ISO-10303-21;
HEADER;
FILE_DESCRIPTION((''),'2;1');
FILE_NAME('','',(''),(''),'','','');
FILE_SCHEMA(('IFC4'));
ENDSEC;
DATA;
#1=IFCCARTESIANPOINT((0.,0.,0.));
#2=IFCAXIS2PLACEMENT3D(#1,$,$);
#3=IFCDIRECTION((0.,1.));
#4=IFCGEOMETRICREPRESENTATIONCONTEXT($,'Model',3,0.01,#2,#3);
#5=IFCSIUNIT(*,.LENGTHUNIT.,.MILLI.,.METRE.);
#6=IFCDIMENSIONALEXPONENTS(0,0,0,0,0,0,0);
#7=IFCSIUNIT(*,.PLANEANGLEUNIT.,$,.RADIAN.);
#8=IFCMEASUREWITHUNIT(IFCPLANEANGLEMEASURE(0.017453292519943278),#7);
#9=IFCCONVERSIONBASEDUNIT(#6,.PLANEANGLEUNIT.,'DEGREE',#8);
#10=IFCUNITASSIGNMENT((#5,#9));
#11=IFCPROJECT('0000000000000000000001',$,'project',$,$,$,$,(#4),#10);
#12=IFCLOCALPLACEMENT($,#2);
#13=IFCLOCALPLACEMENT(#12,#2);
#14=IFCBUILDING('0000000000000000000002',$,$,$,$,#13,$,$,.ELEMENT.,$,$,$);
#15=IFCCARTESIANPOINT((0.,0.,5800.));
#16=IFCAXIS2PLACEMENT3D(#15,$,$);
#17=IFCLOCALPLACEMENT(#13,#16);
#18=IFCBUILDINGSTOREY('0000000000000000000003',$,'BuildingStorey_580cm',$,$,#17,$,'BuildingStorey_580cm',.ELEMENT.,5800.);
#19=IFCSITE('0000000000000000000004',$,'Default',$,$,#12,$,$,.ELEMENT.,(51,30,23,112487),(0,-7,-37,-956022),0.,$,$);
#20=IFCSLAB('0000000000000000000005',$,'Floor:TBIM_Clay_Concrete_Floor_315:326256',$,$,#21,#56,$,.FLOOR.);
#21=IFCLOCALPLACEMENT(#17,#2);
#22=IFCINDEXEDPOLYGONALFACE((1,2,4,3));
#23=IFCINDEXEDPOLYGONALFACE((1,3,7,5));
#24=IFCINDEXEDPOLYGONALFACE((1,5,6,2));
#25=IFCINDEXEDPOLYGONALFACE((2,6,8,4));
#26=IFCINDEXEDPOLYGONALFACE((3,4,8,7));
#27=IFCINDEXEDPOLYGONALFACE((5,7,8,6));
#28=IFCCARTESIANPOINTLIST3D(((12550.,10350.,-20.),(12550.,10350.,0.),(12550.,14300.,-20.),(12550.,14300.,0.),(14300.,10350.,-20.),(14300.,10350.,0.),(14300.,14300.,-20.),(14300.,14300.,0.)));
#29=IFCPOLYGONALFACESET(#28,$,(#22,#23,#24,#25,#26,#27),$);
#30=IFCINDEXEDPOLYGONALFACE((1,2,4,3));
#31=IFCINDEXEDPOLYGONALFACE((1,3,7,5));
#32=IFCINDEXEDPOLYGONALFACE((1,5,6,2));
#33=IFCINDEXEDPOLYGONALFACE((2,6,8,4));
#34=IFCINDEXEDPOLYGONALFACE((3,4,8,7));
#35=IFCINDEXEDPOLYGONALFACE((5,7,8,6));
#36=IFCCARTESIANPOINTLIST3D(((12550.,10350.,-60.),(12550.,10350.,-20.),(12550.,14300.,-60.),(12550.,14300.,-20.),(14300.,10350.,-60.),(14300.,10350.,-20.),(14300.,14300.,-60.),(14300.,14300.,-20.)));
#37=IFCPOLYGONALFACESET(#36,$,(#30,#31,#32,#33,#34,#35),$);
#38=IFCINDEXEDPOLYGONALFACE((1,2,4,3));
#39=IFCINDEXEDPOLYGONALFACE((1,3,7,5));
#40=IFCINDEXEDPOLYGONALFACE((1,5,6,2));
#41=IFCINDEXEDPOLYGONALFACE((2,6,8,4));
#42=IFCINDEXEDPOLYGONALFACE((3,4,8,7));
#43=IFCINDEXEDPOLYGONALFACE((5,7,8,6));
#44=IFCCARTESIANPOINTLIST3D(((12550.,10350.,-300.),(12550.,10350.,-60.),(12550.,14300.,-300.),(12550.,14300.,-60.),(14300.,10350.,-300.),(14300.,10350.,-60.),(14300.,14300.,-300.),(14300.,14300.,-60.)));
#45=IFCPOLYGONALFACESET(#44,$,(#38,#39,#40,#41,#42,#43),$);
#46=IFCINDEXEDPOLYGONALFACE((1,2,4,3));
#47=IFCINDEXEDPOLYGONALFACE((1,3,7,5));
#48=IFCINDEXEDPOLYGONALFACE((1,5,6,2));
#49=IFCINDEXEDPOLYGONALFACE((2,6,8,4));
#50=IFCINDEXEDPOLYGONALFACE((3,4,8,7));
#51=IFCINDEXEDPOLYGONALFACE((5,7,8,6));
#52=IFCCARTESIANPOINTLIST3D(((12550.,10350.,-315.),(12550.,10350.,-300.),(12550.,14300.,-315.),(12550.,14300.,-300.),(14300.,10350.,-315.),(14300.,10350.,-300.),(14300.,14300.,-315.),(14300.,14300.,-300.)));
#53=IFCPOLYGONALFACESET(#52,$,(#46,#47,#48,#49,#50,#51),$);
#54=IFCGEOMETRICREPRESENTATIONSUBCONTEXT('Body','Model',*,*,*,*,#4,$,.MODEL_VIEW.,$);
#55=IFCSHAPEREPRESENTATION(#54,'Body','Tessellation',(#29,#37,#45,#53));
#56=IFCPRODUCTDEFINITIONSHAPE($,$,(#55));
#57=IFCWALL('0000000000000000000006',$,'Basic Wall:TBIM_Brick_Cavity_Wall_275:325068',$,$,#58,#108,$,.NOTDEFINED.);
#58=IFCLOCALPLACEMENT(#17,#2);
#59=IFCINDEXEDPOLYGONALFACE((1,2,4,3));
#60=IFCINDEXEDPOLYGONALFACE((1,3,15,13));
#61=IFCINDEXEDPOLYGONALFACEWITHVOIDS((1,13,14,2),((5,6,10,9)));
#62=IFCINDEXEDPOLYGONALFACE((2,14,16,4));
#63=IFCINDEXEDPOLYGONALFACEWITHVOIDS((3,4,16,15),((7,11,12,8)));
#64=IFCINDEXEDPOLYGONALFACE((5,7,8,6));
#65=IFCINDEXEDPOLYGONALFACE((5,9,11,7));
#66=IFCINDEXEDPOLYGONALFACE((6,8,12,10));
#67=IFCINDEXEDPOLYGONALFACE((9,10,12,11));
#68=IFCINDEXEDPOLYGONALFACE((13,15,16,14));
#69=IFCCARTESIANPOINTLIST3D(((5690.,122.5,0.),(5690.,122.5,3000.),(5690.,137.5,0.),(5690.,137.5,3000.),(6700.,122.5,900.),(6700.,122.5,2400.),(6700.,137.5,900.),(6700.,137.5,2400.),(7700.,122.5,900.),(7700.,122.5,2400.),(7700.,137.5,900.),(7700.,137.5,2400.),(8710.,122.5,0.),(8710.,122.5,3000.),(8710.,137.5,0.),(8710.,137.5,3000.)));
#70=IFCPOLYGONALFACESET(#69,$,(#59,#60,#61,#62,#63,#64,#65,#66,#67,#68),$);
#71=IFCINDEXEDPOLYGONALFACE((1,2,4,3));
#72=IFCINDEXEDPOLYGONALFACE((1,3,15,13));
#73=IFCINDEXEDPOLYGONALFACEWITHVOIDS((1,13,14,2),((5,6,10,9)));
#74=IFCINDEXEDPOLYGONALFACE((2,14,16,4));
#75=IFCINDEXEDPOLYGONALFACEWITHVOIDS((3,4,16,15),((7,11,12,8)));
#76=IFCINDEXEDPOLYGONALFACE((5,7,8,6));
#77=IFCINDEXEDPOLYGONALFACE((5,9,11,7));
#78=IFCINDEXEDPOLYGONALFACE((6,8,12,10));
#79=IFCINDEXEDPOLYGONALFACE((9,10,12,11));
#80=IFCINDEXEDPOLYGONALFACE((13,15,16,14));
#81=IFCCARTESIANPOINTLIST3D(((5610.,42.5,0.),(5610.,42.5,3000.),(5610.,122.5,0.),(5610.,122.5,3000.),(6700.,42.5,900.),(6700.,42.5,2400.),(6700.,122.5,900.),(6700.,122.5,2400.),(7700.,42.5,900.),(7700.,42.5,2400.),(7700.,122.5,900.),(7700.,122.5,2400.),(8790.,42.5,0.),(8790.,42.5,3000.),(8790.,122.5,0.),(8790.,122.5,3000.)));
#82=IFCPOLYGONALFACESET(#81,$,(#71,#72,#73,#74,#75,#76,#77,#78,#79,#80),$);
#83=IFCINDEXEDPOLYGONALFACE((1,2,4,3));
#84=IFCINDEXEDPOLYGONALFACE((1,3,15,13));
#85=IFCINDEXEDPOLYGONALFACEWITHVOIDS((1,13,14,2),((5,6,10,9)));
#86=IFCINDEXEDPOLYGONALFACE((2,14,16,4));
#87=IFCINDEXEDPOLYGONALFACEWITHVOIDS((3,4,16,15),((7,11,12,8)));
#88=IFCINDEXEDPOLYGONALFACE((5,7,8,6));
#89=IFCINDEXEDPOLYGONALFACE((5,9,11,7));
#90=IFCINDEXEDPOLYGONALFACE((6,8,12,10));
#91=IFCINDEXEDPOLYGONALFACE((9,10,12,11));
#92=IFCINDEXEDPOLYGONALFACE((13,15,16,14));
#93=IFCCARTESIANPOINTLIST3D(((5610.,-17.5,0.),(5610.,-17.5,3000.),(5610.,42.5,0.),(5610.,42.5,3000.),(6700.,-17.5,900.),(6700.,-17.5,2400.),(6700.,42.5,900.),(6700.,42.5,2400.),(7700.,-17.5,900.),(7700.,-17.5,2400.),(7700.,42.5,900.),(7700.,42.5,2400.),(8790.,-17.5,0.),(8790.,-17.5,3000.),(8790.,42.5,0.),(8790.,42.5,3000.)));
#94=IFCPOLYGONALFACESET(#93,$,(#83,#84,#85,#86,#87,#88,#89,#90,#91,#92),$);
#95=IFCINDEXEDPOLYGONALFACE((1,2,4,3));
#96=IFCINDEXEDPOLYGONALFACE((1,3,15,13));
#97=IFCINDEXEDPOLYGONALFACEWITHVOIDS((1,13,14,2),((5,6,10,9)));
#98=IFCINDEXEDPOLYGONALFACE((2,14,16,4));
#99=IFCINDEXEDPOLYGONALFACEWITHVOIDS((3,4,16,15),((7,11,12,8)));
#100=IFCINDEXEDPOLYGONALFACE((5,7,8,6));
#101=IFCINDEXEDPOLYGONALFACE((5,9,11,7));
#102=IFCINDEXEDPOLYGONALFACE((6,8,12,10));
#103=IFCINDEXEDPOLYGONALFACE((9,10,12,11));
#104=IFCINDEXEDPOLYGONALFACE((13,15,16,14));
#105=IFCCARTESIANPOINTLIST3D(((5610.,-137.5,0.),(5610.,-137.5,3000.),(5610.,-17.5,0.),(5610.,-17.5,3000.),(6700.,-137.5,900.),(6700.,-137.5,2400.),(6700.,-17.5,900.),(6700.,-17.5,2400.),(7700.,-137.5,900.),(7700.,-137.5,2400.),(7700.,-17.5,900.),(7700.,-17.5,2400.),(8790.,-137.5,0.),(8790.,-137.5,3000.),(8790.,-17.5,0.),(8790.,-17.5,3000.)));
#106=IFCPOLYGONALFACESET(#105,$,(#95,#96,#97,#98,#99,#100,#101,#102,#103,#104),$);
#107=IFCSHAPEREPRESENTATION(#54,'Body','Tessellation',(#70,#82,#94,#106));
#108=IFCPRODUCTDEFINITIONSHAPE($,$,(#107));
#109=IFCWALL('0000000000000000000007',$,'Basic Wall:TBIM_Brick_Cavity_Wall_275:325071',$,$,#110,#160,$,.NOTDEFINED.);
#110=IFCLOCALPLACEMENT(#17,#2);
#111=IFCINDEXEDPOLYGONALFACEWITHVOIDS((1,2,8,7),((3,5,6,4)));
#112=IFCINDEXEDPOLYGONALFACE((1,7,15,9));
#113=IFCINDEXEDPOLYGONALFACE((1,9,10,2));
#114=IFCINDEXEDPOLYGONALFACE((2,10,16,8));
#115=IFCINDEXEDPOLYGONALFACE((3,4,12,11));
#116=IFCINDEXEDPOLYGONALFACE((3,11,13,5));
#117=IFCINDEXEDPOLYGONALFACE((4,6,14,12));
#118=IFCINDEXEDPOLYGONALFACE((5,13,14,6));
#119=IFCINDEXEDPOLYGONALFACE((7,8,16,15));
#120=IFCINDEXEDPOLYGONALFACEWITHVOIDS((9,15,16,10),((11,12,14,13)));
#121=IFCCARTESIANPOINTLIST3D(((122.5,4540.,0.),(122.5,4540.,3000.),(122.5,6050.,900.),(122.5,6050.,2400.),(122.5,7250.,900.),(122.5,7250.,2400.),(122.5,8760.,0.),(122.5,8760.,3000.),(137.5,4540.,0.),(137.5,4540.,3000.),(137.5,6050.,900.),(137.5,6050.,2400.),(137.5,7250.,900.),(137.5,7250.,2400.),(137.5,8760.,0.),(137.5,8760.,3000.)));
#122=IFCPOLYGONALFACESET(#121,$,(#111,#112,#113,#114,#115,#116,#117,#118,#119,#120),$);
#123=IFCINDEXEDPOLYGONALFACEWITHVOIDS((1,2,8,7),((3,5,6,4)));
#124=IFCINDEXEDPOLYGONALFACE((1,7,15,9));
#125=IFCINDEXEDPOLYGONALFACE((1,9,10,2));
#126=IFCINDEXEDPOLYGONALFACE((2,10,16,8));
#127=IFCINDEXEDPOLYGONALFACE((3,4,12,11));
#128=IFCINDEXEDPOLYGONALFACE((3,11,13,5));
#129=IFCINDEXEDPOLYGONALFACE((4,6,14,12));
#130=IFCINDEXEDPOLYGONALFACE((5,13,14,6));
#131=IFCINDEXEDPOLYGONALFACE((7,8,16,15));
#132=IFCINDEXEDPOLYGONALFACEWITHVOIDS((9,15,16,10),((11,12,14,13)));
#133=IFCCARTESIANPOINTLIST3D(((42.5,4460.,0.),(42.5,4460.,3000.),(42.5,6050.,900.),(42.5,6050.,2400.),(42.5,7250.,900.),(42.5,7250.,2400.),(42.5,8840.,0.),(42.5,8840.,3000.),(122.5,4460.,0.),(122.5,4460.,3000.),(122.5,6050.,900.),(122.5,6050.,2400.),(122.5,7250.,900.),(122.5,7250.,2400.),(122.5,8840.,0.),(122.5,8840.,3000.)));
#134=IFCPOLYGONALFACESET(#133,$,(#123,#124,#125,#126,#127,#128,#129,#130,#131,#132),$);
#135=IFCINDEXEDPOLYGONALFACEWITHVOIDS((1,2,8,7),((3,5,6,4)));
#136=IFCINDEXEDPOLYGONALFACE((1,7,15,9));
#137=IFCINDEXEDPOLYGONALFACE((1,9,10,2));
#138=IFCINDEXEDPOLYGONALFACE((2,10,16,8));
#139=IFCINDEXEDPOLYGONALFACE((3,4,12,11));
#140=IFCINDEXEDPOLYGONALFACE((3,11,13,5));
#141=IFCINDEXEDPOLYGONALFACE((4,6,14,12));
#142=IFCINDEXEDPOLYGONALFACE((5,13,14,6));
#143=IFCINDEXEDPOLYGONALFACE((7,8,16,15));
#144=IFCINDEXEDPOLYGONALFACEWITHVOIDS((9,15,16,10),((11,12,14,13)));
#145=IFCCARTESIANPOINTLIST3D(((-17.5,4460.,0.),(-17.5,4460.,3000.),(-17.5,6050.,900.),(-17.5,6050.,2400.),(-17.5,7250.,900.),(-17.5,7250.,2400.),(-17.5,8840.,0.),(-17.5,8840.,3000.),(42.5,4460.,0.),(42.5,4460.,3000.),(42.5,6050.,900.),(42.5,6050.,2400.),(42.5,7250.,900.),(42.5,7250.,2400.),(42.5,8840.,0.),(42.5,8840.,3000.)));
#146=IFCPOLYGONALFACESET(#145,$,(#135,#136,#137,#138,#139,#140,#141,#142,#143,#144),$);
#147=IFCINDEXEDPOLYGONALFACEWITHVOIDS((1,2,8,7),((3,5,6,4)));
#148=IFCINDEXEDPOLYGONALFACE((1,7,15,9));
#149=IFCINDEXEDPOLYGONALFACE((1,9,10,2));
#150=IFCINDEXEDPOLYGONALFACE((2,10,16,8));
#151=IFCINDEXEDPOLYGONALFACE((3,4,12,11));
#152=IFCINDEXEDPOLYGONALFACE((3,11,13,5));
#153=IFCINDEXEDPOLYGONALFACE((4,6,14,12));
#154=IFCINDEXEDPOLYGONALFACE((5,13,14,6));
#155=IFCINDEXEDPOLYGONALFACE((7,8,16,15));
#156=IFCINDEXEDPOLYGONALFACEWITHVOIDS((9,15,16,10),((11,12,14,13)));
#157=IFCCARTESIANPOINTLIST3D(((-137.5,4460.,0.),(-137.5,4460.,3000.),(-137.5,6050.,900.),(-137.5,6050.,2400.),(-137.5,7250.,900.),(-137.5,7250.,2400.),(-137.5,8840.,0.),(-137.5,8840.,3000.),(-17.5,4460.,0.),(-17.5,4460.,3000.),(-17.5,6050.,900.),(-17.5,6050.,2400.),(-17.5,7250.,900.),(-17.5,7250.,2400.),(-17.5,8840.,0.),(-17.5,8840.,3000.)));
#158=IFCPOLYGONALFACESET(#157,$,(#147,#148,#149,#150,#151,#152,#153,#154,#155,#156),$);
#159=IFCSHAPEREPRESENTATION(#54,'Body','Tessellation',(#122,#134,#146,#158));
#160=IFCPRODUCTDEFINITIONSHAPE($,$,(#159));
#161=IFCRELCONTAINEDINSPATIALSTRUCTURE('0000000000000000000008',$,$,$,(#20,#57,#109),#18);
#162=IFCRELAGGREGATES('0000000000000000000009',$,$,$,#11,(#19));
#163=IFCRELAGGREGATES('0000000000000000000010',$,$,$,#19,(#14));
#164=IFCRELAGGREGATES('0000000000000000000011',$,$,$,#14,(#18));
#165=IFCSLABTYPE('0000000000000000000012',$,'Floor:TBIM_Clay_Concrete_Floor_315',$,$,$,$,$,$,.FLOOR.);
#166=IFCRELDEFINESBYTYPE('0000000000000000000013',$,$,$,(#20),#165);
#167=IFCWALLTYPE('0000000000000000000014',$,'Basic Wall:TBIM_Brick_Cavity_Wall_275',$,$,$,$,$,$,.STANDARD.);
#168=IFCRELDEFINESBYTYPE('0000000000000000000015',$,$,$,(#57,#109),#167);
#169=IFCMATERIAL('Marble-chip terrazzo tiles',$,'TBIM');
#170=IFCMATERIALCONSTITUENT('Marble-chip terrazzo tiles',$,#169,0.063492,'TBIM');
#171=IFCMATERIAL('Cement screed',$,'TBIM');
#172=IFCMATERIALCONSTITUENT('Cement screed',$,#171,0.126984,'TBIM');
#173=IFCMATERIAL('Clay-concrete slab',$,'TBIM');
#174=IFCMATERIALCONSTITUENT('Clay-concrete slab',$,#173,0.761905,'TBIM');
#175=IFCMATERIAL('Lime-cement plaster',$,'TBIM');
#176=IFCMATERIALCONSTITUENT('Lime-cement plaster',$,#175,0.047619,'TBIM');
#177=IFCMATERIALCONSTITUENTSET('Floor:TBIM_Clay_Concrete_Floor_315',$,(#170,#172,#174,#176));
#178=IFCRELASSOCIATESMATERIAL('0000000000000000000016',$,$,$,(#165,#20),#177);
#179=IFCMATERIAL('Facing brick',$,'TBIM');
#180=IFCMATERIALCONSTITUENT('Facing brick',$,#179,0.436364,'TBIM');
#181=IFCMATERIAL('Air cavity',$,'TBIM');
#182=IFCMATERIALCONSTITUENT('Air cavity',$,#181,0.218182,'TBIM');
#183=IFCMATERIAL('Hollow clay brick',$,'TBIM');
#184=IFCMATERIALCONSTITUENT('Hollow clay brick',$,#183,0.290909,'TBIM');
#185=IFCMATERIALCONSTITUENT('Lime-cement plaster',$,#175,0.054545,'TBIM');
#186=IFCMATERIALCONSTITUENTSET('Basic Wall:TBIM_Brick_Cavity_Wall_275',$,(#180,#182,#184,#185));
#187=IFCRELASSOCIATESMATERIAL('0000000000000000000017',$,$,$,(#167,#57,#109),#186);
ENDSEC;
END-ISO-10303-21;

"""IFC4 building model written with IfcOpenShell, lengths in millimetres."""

from ifc_helpers import new_model, entity, si_unit, converted_unit, direction, frame, origin, place, context, subcontext, project, spatial, indexed_curve, outline, extrude, material, constituent, constituent_set, type_object, element, save


model = new_model("IFC4")

# Units and contexts
model_context = context("Model", 3, precision=0.01, world=origin(), true_north=direction((0.0, 1.0)))
body_context = subcontext(model_context, "Body", "Model", "MODEL_VIEW")
ifc_project = project(units=[si_unit("LENGTHUNIT", "METRE", prefix="MILLI"), converted_unit("PLANEANGLEUNIT", "DEGREE", entity("IfcPlaneAngleMeasure", 0.017453292519943278), si_unit("PLANEANGLEUNIT", "RADIAN"), dimensions=[0, 0, 0, 0, 0, 0, 0])], contexts=[model_context])

# Site, building, storey
site_placement = place(None, origin())
site = spatial("IfcSite", under=ifc_project, at=site_placement, Name="Default", CompositionType="ELEMENT", RefLatitude=(51, 30, 23, 112487), RefLongitude=(0, -7, -37, -956022), RefElevation=0.0)
building_placement = place(site_placement, origin())
building = spatial("IfcBuilding", under=site, at=building_placement, CompositionType="ELEMENT")
storey_placement = place(building_placement, frame((0.0, 0.0, 5800.0)))
storey = spatial("IfcBuildingStorey", under=building, at=storey_placement, Name="BuildingStorey_580cm", LongName="BuildingStorey_580cm", CompositionType="ELEMENT", Elevation=5800.0)

# Slab
ifc_material_1 = material(Name="Marble-chip terrazzo tiles", Category="TBIM")
ifc_constituent_1 = constituent(ifc_material_1, Name="Marble-chip terrazzo tiles", Category="TBIM", fraction=0.063492)
ifc_material_2 = material(Name="Cement screed", Category="TBIM")
ifc_constituent_2 = constituent(ifc_material_2, Name="Cement screed", Category="TBIM", fraction=0.126984)
ifc_material_3 = material(Name="Clay-concrete slab", Category="TBIM")
ifc_constituent_3 = constituent(ifc_material_3, Name="Clay-concrete slab", Category="TBIM", fraction=0.761905)
ifc_material_4 = material(Name="Lime-cement plaster", Category="TBIM")
ifc_constituent_4 = constituent(ifc_material_4, Name="Lime-cement plaster", Category="TBIM", fraction=0.047619)
ifc_constituent_set_1 = constituent_set(constituents=[ifc_constituent_1, ifc_constituent_2, ifc_constituent_3, ifc_constituent_4], Name="Floor:TBIM_Clay_Concrete_Floor_315")
slab_type = type_object("IfcSlabType", Name="Floor:TBIM_Clay_Concrete_Floor_315", PredefinedType="FLOOR", material=ifc_constituent_set_1)
slab_1_placement = place(storey_placement, origin())
element("IfcSlab", 1, at=slab_1_placement, inside=storey, type_object=slab_type, material=ifc_constituent_set_1, Name="Floor:TBIM_Clay_Concrete_Floor_315:326256", PredefinedType="FLOOR", context=body_context, shape_type="SweptSolid", body=[
    extrude(outline(indexed_curve([(-875.0, -1975.0), (875.0, -1975.0), (875.0, 1975.0), (-875.0, 1975.0), (-875.0, -1975.0)], self_intersect=False)), frame((13425.0, 12325.0, -20.0), z_axis=(0.0, 0.0, 1.0), x_axis=(-1.0, 0.0, 0.0)), (0.0, 0.0, 1.0), 20.0),
    extrude(outline(indexed_curve([(-875.0, -1975.0), (875.0, -1975.0), (875.0, 1975.0), (-875.0, 1975.0), (-875.0, -1975.0)], self_intersect=False)), frame((13425.0, 12325.0, -60.0), z_axis=(0.0, 0.0, 1.0), x_axis=(-1.0, 0.0, 0.0)), (0.0, 0.0, 1.0), 40.0),
    extrude(outline(indexed_curve([(-875.0, -1975.0), (875.0, -1975.0), (875.0, 1975.0), (-875.0, 1975.0), (-875.0, -1975.0)], self_intersect=False)), frame((13425.0, 12325.0, -300.0), z_axis=(0.0, 0.0, 1.0), x_axis=(-1.0, 0.0, 0.0)), (0.0, 0.0, 1.0), 240.0),
    extrude(outline(indexed_curve([(-875.0, -1975.0), (875.0, -1975.0), (875.0, 1975.0), (-875.0, 1975.0), (-875.0, -1975.0)], self_intersect=False)), frame((13425.0, 12325.0, -315.0), z_axis=(0.0, 0.0, 1.0), x_axis=(-1.0, 0.0, 0.0)), (0.0, 0.0, 1.0), 15.0),
])

# Walls, openings
ifc_material_5 = material(Name="Facing brick", Category="TBIM")
ifc_constituent_5 = constituent(ifc_material_5, Name="Facing brick", Category="TBIM", fraction=0.436364)
ifc_material_6 = material(Name="Air cavity", Category="TBIM")
ifc_constituent_6 = constituent(ifc_material_6, Name="Air cavity", Category="TBIM", fraction=0.218182)
ifc_material_7 = material(Name="Hollow clay brick", Category="TBIM")
ifc_constituent_7 = constituent(ifc_material_7, Name="Hollow clay brick", Category="TBIM", fraction=0.290909)
ifc_constituent_8 = constituent(ifc_material_4, Name="Lime-cement plaster", Category="TBIM", fraction=0.054545)
ifc_constituent_set_2 = constituent_set(constituents=[ifc_constituent_5, ifc_constituent_6, ifc_constituent_7, ifc_constituent_8], Name="Basic Wall:TBIM_Brick_Cavity_Wall_275")
wall_type_1 = type_object("IfcWallType", Name="Basic Wall:TBIM_Brick_Cavity_Wall_275", PredefinedType="STANDARD", material=ifc_constituent_set_2)
wall_1_placement = place(storey_placement, frame((5595.0, 0.0, 0.0)))
wall_1 = element("IfcWall", 2, at=wall_1_placement, inside=storey, type_object=wall_type_1, material=ifc_constituent_set_2, Name="Basic Wall:TBIM_Brick_Cavity_Wall_275:325068", PredefinedType="NOTDEFINED", context=body_context, shape_type="SweptSolid", body=[
    extrude(outline(indexed_curve([(-1500.0, -1510.0), (1500.0, -1510.0), (1500.0, 1510.0), (-1500.0, 1510.0), (-1500.0, -1510.0)], self_intersect=False), holes=[indexed_curve([(-600.0, -500.0), (-600.0, 500.0), (900.0, 500.0), (900.0, -500.0), (-600.0, -500.0)], self_intersect=False)]), frame((1605.0, 122.5, 1500.0), z_axis=(0.0, 1.0, 0.0), x_axis=(0.0, 0.0, 1.0)), (0.0, 0.0, 1.0), 15.0),
    extrude(outline(indexed_curve([(-1500.0, -1590.0), (1500.0, -1590.0), (1500.0, 1590.0), (-1500.0, 1590.0), (-1500.0, -1590.0)], self_intersect=False), holes=[indexed_curve([(-600.0, -500.0), (-600.0, 500.0), (900.0, 500.0), (900.0, -500.0), (-600.0, -500.0)], self_intersect=False)]), frame((1605.0, 42.5, 1500.0), z_axis=(0.0, 1.0, 0.0), x_axis=(0.0, 0.0, 1.0)), (0.0, 0.0, 1.0), 80.0),
    extrude(outline(indexed_curve([(-1500.0, -1590.0), (1500.0, -1590.0), (1500.0, 1590.0), (-1500.0, 1590.0), (-1500.0, -1590.0)], self_intersect=False), holes=[indexed_curve([(-600.0, -500.0), (-600.0, 500.0), (900.0, 500.0), (900.0, -500.0), (-600.0, -500.0)], self_intersect=False)]), frame((1605.0, -17.5, 1500.0), z_axis=(0.0, 1.0, 0.0), x_axis=(0.0, 0.0, 1.0)), (0.0, 0.0, 1.0), 60.0),
    extrude(outline(indexed_curve([(-1500.0, -1590.0), (1500.0, -1590.0), (1500.0, 1590.0), (-1500.0, 1590.0), (-1500.0, -1590.0)], self_intersect=False), holes=[indexed_curve([(900.0, -500.0), (-600.0, -500.0), (-600.0, 500.0), (900.0, 500.0), (900.0, -500.0)], self_intersect=False)]), frame((1605.0, -137.5, 1500.0), z_axis=(0.0, 1.0, 0.0), x_axis=(0.0, 0.0, 1.0)), (0.0, 0.0, 1.0), 120.0),
])
opening_1_placement = place(wall_1_placement, frame((1105.0, -137.5, 900.0)))
element("IfcOpeningElement", 3, at=opening_1_placement, cuts=wall_1, PredefinedType="OPENING", context=body_context, shape_type="SweptSolid", body=[
    extrude(outline(indexed_curve([(1500.0, 0.0), (1500.0, 1000.0), (0.0, 1000.0), (0.0, 0.0), (1500.0, 0.0)], self_intersect=False)), frame((0.0, 0.0, 0.0), z_axis=(0.0, 1.0, 0.0), x_axis=(0.0, 0.0, 1.0)), (0.0, 0.0, 1.0), 275.0),
])
wall_2_placement = place(storey_placement, frame((0.0, 4445.0, 0.0), z_axis=(0.0, 0.0, 1.0), x_axis=(0.0, 1.0, 0.0)))
wall_2 = element("IfcWall", 4, at=wall_2_placement, inside=storey, type_object=wall_type_1, material=ifc_constituent_set_2, Name="Basic Wall:TBIM_Brick_Cavity_Wall_275:325071", PredefinedType="NOTDEFINED", context=body_context, shape_type="SweptSolid", body=[
    extrude(outline(indexed_curve([(-1500.0, -2110.0), (1500.0, -2110.0), (1500.0, 2110.0), (-1500.0, 2110.0), (-1500.0, -2110.0)], self_intersect=False), holes=[indexed_curve([(900.0, 600.0), (900.0, -600.0), (-600.0, -600.0), (-600.0, 600.0), (900.0, 600.0)], self_intersect=False)]), frame((2205.0, -122.5, 1500.0), z_axis=(0.0, -1.0, 0.0), x_axis=(0.0, 0.0, 1.0)), (0.0, 0.0, 1.0), 15.0),
    extrude(outline(indexed_curve([(-1500.0, -2190.0), (1500.0, -2190.0), (1500.0, 2190.0), (-1500.0, 2190.0), (-1500.0, -2190.0)], self_intersect=False), holes=[indexed_curve([(900.0, 600.0), (900.0, -600.0), (-600.0, -600.0), (-600.0, 600.0), (900.0, 600.0)], self_intersect=False)]), frame((2205.0, -42.5, 1500.0), z_axis=(0.0, -1.0, 0.0), x_axis=(0.0, 0.0, 1.0)), (0.0, 0.0, 1.0), 80.0),
    extrude(outline(indexed_curve([(-1500.0, -2190.0), (1500.0, -2190.0), (1500.0, 2190.0), (-1500.0, 2190.0), (-1500.0, -2190.0)], self_intersect=False), holes=[indexed_curve([(900.0, 600.0), (900.0, -600.0), (-600.0, -600.0), (-600.0, 600.0), (900.0, 600.0)], self_intersect=False)]), frame((2205.0, 17.5, 1500.0), z_axis=(0.0, -1.0, 0.0), x_axis=(0.0, 0.0, 1.0)), (0.0, 0.0, 1.0), 60.0),
    extrude(outline(indexed_curve([(-2190.0, -1500.0), (2190.0, -1500.0), (2190.0, 1500.0), (-2190.0, 1500.0), (-2190.0, -1500.0)], self_intersect=False), holes=[indexed_curve([(-600.0, 900.0), (600.0, 900.0), (600.0, -600.0), (-600.0, -600.0), (-600.0, 900.0)], self_intersect=False)]), frame((2205.0, 137.5, 1500.0), z_axis=(0.0, -1.0, 0.0), x_axis=(1.0, 0.0, 0.0)), (0.0, 0.0, 1.0), 120.0),
])
opening_2_placement = place(wall_2_placement, frame((1605.0, -137.5, 900.0)))
element("IfcOpeningElement", 5, at=opening_2_placement, cuts=wall_2, PredefinedType="OPENING", context=body_context, shape_type="SweptSolid", body=[
    extrude(outline(indexed_curve([(1500.0, 0.0), (1500.0, 1200.0), (0.0, 1200.0), (0.0, 0.0), (1500.0, 0.0)], self_intersect=False)), frame((0.0, 0.0, 0.0), z_axis=(0.0, 1.0, 0.0), x_axis=(0.0, 0.0, 1.0)), (0.0, 0.0, 1.0), 275.0),
])

save(model, "model.ifc")
